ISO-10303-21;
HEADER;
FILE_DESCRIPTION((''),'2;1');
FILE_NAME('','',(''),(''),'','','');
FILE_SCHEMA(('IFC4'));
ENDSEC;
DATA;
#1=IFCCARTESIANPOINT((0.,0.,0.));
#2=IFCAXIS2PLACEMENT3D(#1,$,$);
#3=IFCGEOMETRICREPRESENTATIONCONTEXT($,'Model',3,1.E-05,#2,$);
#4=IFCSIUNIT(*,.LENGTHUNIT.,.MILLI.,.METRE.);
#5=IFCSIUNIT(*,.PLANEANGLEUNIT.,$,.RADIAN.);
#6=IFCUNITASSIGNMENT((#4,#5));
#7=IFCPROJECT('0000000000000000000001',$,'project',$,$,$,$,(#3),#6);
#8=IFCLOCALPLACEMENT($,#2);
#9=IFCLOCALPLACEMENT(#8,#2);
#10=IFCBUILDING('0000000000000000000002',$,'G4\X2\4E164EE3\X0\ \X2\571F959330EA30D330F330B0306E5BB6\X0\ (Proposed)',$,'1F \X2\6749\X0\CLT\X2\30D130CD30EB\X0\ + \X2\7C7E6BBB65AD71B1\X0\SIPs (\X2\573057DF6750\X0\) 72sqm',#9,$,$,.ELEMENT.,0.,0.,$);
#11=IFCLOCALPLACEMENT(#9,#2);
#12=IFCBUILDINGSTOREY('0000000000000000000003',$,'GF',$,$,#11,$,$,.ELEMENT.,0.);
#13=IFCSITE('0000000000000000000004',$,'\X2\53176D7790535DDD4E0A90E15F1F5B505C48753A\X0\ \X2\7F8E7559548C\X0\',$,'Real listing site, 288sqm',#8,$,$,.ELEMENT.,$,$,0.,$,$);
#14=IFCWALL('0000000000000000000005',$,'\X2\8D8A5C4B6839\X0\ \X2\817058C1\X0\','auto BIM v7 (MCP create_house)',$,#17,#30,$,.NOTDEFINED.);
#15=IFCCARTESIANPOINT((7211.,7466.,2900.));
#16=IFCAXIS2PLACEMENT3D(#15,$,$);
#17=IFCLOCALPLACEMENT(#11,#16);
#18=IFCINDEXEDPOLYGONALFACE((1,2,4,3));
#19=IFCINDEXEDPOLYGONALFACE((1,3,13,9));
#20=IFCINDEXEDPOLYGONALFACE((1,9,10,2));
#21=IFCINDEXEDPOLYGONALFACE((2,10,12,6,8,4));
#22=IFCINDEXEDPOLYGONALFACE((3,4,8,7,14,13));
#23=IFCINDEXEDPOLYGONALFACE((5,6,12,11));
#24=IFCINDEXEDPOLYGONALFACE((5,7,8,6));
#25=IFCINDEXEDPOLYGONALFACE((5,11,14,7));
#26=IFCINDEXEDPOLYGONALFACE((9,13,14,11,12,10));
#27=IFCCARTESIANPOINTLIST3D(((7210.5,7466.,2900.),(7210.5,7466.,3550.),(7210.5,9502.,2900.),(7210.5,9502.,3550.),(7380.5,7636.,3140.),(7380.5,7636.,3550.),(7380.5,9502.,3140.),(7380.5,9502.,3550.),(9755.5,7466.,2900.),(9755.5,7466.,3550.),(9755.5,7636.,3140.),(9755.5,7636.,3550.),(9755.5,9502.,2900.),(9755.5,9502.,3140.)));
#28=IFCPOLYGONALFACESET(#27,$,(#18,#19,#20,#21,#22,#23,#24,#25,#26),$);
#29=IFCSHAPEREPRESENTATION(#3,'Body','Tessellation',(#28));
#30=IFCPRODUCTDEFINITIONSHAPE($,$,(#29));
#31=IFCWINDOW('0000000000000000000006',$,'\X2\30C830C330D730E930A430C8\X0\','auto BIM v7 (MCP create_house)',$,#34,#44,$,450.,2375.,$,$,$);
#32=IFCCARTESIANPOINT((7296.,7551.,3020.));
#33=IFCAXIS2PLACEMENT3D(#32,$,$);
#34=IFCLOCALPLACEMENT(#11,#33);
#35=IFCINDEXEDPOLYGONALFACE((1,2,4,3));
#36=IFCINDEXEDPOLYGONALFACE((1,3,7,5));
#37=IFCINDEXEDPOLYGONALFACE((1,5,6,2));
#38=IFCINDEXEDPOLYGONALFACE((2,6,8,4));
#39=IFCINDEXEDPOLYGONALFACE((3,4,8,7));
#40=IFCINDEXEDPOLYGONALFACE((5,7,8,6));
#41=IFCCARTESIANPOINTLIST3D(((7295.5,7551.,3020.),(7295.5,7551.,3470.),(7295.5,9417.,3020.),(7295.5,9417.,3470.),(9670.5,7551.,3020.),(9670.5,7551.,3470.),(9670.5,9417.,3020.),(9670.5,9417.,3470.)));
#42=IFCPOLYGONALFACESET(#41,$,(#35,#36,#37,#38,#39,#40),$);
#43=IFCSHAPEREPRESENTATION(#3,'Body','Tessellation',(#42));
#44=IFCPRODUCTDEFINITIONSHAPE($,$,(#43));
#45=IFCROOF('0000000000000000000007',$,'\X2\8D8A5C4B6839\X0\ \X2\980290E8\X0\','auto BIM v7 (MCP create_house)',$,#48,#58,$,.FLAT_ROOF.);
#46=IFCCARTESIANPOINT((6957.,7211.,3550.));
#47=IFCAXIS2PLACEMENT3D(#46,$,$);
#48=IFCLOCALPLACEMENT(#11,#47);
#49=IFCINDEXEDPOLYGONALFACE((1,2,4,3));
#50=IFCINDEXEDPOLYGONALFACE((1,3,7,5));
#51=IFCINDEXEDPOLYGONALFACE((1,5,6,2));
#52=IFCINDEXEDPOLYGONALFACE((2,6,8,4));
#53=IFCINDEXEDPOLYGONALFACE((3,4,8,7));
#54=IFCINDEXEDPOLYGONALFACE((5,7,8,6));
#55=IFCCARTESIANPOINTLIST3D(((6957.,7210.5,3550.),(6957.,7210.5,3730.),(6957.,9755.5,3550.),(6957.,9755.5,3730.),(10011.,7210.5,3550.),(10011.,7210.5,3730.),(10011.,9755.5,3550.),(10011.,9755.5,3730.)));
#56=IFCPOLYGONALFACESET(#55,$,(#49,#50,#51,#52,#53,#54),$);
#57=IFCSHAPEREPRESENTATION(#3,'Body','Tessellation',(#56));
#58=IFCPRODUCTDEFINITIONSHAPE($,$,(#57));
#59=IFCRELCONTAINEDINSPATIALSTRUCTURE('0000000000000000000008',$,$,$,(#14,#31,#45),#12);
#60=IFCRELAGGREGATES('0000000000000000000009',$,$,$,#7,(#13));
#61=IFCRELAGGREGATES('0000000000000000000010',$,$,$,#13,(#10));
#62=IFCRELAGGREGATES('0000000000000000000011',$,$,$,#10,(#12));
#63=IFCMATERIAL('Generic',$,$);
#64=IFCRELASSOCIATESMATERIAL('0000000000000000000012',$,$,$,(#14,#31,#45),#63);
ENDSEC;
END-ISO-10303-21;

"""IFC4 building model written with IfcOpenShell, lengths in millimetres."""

from ifc_helpers import new_model, si_unit, frame, frame_2d, origin, place, context, project, spatial, rectangle, extrude, material, element, fill, save


model = new_model("IFC4")

# Units and contexts
model_context = context("Model", 3, precision=1e-05, world=origin())
ifc_project = project(units=[si_unit("LENGTHUNIT", "METRE", prefix="MILLI"), si_unit("PLANEANGLEUNIT", "RADIAN")], contexts=[model_context])

# Site, building, storey
site_placement = place(None, origin())
site = spatial("IfcSite", under=ifc_project, at=site_placement, Name="北海道川上郡弟子屈町 美留和", ObjectType="Real listing site, 288sqm", CompositionType="ELEMENT", RefElevation=0.0)
building_placement = place(site_placement, origin())
building = spatial("IfcBuilding", under=site, at=building_placement, Name="G4世代 土間リビングの家 (Proposed)", ObjectType="1F 杉CLTパネル + 籾殻断熱SIPs (地域材) 72sqm", CompositionType="ELEMENT", ElevationOfRefHeight=0.0, ElevationOfTerrain=0.0)
storey_placement = place(building_placement, origin())
storey = spatial("IfcBuildingStorey", under=building, at=storey_placement, Name="GF", CompositionType="ELEMENT", Elevation=0.0)

# Shared definitions
ifc_material = material(Name="Generic")

# Wall, opening, window
wall_1_placement = place(storey_placement, frame((7211.0, 7466.0, 2900.0)))
wall_1 = element("IfcWall", 1, at=wall_1_placement, inside=storey, material=ifc_material, Name="越屋根 腰壁", Description="auto BIM v7 (MCP create_house)", PredefinedType="NOTDEFINED", context=model_context, shape_type="SweptSolid", body=[
    extrude(rectangle(XDim=2545.0, YDim=2036.0, at=frame_2d((1272.0, 1018.0))), frame((7211.0, 7466.0, 2900.0)), (0.0, 0.0, 1.0), 650.0),
])
opening_1_placement = place(storey_placement, frame((7296.0, 7551.0, 3020.0)))
opening_1 = element("IfcOpeningElement", 2, at=opening_1_placement, cuts=wall_1, PredefinedType="NOTDEFINED", context=model_context, shape_type="SweptSolid", body=[
    extrude(rectangle(XDim=2375.0, YDim=1866.0, at=frame_2d((1187.0, 933.0))), frame((7296.0, 7551.0, 3020.0)), (0.0, 0.0, 1.0), 450.0),
])
window_1_placement = place(storey_placement, frame((7296.0, 7551.0, 3020.0)))
window_1 = element("IfcWindow", 3, at=window_1_placement, inside=storey, material=ifc_material, Name="トップライト", Description="auto BIM v7 (MCP create_house)", OverallHeight=450.0, OverallWidth=2375.0, context=model_context, shape_type="SweptSolid", body=[
    extrude(rectangle(XDim=2375.0, YDim=1866.0, at=frame_2d((1187.0, 933.0))), frame((7296.0, 7551.0, 3020.0)), (0.0, 0.0, 1.0), 450.0),
])
fill(opening_1, window_1)

# Roof
roof_1_placement = place(storey_placement, frame((6957.0, 7211.0, 3550.0)))
element("IfcRoof", 4, at=roof_1_placement, inside=storey, material=ifc_material, Name="越屋根 頂部", Description="auto BIM v7 (MCP create_house)", PredefinedType="FLAT_ROOF", context=model_context, shape_type="SweptSolid", body=[
    extrude(rectangle(XDim=3054.0, YDim=2545.0, at=frame_2d((1527.0, 1272.0))), frame((6957.0, 7211.0, 3550.0)), (0.0, 0.0, 1.0), 180.0),
])

save(model, "model.ifc")
